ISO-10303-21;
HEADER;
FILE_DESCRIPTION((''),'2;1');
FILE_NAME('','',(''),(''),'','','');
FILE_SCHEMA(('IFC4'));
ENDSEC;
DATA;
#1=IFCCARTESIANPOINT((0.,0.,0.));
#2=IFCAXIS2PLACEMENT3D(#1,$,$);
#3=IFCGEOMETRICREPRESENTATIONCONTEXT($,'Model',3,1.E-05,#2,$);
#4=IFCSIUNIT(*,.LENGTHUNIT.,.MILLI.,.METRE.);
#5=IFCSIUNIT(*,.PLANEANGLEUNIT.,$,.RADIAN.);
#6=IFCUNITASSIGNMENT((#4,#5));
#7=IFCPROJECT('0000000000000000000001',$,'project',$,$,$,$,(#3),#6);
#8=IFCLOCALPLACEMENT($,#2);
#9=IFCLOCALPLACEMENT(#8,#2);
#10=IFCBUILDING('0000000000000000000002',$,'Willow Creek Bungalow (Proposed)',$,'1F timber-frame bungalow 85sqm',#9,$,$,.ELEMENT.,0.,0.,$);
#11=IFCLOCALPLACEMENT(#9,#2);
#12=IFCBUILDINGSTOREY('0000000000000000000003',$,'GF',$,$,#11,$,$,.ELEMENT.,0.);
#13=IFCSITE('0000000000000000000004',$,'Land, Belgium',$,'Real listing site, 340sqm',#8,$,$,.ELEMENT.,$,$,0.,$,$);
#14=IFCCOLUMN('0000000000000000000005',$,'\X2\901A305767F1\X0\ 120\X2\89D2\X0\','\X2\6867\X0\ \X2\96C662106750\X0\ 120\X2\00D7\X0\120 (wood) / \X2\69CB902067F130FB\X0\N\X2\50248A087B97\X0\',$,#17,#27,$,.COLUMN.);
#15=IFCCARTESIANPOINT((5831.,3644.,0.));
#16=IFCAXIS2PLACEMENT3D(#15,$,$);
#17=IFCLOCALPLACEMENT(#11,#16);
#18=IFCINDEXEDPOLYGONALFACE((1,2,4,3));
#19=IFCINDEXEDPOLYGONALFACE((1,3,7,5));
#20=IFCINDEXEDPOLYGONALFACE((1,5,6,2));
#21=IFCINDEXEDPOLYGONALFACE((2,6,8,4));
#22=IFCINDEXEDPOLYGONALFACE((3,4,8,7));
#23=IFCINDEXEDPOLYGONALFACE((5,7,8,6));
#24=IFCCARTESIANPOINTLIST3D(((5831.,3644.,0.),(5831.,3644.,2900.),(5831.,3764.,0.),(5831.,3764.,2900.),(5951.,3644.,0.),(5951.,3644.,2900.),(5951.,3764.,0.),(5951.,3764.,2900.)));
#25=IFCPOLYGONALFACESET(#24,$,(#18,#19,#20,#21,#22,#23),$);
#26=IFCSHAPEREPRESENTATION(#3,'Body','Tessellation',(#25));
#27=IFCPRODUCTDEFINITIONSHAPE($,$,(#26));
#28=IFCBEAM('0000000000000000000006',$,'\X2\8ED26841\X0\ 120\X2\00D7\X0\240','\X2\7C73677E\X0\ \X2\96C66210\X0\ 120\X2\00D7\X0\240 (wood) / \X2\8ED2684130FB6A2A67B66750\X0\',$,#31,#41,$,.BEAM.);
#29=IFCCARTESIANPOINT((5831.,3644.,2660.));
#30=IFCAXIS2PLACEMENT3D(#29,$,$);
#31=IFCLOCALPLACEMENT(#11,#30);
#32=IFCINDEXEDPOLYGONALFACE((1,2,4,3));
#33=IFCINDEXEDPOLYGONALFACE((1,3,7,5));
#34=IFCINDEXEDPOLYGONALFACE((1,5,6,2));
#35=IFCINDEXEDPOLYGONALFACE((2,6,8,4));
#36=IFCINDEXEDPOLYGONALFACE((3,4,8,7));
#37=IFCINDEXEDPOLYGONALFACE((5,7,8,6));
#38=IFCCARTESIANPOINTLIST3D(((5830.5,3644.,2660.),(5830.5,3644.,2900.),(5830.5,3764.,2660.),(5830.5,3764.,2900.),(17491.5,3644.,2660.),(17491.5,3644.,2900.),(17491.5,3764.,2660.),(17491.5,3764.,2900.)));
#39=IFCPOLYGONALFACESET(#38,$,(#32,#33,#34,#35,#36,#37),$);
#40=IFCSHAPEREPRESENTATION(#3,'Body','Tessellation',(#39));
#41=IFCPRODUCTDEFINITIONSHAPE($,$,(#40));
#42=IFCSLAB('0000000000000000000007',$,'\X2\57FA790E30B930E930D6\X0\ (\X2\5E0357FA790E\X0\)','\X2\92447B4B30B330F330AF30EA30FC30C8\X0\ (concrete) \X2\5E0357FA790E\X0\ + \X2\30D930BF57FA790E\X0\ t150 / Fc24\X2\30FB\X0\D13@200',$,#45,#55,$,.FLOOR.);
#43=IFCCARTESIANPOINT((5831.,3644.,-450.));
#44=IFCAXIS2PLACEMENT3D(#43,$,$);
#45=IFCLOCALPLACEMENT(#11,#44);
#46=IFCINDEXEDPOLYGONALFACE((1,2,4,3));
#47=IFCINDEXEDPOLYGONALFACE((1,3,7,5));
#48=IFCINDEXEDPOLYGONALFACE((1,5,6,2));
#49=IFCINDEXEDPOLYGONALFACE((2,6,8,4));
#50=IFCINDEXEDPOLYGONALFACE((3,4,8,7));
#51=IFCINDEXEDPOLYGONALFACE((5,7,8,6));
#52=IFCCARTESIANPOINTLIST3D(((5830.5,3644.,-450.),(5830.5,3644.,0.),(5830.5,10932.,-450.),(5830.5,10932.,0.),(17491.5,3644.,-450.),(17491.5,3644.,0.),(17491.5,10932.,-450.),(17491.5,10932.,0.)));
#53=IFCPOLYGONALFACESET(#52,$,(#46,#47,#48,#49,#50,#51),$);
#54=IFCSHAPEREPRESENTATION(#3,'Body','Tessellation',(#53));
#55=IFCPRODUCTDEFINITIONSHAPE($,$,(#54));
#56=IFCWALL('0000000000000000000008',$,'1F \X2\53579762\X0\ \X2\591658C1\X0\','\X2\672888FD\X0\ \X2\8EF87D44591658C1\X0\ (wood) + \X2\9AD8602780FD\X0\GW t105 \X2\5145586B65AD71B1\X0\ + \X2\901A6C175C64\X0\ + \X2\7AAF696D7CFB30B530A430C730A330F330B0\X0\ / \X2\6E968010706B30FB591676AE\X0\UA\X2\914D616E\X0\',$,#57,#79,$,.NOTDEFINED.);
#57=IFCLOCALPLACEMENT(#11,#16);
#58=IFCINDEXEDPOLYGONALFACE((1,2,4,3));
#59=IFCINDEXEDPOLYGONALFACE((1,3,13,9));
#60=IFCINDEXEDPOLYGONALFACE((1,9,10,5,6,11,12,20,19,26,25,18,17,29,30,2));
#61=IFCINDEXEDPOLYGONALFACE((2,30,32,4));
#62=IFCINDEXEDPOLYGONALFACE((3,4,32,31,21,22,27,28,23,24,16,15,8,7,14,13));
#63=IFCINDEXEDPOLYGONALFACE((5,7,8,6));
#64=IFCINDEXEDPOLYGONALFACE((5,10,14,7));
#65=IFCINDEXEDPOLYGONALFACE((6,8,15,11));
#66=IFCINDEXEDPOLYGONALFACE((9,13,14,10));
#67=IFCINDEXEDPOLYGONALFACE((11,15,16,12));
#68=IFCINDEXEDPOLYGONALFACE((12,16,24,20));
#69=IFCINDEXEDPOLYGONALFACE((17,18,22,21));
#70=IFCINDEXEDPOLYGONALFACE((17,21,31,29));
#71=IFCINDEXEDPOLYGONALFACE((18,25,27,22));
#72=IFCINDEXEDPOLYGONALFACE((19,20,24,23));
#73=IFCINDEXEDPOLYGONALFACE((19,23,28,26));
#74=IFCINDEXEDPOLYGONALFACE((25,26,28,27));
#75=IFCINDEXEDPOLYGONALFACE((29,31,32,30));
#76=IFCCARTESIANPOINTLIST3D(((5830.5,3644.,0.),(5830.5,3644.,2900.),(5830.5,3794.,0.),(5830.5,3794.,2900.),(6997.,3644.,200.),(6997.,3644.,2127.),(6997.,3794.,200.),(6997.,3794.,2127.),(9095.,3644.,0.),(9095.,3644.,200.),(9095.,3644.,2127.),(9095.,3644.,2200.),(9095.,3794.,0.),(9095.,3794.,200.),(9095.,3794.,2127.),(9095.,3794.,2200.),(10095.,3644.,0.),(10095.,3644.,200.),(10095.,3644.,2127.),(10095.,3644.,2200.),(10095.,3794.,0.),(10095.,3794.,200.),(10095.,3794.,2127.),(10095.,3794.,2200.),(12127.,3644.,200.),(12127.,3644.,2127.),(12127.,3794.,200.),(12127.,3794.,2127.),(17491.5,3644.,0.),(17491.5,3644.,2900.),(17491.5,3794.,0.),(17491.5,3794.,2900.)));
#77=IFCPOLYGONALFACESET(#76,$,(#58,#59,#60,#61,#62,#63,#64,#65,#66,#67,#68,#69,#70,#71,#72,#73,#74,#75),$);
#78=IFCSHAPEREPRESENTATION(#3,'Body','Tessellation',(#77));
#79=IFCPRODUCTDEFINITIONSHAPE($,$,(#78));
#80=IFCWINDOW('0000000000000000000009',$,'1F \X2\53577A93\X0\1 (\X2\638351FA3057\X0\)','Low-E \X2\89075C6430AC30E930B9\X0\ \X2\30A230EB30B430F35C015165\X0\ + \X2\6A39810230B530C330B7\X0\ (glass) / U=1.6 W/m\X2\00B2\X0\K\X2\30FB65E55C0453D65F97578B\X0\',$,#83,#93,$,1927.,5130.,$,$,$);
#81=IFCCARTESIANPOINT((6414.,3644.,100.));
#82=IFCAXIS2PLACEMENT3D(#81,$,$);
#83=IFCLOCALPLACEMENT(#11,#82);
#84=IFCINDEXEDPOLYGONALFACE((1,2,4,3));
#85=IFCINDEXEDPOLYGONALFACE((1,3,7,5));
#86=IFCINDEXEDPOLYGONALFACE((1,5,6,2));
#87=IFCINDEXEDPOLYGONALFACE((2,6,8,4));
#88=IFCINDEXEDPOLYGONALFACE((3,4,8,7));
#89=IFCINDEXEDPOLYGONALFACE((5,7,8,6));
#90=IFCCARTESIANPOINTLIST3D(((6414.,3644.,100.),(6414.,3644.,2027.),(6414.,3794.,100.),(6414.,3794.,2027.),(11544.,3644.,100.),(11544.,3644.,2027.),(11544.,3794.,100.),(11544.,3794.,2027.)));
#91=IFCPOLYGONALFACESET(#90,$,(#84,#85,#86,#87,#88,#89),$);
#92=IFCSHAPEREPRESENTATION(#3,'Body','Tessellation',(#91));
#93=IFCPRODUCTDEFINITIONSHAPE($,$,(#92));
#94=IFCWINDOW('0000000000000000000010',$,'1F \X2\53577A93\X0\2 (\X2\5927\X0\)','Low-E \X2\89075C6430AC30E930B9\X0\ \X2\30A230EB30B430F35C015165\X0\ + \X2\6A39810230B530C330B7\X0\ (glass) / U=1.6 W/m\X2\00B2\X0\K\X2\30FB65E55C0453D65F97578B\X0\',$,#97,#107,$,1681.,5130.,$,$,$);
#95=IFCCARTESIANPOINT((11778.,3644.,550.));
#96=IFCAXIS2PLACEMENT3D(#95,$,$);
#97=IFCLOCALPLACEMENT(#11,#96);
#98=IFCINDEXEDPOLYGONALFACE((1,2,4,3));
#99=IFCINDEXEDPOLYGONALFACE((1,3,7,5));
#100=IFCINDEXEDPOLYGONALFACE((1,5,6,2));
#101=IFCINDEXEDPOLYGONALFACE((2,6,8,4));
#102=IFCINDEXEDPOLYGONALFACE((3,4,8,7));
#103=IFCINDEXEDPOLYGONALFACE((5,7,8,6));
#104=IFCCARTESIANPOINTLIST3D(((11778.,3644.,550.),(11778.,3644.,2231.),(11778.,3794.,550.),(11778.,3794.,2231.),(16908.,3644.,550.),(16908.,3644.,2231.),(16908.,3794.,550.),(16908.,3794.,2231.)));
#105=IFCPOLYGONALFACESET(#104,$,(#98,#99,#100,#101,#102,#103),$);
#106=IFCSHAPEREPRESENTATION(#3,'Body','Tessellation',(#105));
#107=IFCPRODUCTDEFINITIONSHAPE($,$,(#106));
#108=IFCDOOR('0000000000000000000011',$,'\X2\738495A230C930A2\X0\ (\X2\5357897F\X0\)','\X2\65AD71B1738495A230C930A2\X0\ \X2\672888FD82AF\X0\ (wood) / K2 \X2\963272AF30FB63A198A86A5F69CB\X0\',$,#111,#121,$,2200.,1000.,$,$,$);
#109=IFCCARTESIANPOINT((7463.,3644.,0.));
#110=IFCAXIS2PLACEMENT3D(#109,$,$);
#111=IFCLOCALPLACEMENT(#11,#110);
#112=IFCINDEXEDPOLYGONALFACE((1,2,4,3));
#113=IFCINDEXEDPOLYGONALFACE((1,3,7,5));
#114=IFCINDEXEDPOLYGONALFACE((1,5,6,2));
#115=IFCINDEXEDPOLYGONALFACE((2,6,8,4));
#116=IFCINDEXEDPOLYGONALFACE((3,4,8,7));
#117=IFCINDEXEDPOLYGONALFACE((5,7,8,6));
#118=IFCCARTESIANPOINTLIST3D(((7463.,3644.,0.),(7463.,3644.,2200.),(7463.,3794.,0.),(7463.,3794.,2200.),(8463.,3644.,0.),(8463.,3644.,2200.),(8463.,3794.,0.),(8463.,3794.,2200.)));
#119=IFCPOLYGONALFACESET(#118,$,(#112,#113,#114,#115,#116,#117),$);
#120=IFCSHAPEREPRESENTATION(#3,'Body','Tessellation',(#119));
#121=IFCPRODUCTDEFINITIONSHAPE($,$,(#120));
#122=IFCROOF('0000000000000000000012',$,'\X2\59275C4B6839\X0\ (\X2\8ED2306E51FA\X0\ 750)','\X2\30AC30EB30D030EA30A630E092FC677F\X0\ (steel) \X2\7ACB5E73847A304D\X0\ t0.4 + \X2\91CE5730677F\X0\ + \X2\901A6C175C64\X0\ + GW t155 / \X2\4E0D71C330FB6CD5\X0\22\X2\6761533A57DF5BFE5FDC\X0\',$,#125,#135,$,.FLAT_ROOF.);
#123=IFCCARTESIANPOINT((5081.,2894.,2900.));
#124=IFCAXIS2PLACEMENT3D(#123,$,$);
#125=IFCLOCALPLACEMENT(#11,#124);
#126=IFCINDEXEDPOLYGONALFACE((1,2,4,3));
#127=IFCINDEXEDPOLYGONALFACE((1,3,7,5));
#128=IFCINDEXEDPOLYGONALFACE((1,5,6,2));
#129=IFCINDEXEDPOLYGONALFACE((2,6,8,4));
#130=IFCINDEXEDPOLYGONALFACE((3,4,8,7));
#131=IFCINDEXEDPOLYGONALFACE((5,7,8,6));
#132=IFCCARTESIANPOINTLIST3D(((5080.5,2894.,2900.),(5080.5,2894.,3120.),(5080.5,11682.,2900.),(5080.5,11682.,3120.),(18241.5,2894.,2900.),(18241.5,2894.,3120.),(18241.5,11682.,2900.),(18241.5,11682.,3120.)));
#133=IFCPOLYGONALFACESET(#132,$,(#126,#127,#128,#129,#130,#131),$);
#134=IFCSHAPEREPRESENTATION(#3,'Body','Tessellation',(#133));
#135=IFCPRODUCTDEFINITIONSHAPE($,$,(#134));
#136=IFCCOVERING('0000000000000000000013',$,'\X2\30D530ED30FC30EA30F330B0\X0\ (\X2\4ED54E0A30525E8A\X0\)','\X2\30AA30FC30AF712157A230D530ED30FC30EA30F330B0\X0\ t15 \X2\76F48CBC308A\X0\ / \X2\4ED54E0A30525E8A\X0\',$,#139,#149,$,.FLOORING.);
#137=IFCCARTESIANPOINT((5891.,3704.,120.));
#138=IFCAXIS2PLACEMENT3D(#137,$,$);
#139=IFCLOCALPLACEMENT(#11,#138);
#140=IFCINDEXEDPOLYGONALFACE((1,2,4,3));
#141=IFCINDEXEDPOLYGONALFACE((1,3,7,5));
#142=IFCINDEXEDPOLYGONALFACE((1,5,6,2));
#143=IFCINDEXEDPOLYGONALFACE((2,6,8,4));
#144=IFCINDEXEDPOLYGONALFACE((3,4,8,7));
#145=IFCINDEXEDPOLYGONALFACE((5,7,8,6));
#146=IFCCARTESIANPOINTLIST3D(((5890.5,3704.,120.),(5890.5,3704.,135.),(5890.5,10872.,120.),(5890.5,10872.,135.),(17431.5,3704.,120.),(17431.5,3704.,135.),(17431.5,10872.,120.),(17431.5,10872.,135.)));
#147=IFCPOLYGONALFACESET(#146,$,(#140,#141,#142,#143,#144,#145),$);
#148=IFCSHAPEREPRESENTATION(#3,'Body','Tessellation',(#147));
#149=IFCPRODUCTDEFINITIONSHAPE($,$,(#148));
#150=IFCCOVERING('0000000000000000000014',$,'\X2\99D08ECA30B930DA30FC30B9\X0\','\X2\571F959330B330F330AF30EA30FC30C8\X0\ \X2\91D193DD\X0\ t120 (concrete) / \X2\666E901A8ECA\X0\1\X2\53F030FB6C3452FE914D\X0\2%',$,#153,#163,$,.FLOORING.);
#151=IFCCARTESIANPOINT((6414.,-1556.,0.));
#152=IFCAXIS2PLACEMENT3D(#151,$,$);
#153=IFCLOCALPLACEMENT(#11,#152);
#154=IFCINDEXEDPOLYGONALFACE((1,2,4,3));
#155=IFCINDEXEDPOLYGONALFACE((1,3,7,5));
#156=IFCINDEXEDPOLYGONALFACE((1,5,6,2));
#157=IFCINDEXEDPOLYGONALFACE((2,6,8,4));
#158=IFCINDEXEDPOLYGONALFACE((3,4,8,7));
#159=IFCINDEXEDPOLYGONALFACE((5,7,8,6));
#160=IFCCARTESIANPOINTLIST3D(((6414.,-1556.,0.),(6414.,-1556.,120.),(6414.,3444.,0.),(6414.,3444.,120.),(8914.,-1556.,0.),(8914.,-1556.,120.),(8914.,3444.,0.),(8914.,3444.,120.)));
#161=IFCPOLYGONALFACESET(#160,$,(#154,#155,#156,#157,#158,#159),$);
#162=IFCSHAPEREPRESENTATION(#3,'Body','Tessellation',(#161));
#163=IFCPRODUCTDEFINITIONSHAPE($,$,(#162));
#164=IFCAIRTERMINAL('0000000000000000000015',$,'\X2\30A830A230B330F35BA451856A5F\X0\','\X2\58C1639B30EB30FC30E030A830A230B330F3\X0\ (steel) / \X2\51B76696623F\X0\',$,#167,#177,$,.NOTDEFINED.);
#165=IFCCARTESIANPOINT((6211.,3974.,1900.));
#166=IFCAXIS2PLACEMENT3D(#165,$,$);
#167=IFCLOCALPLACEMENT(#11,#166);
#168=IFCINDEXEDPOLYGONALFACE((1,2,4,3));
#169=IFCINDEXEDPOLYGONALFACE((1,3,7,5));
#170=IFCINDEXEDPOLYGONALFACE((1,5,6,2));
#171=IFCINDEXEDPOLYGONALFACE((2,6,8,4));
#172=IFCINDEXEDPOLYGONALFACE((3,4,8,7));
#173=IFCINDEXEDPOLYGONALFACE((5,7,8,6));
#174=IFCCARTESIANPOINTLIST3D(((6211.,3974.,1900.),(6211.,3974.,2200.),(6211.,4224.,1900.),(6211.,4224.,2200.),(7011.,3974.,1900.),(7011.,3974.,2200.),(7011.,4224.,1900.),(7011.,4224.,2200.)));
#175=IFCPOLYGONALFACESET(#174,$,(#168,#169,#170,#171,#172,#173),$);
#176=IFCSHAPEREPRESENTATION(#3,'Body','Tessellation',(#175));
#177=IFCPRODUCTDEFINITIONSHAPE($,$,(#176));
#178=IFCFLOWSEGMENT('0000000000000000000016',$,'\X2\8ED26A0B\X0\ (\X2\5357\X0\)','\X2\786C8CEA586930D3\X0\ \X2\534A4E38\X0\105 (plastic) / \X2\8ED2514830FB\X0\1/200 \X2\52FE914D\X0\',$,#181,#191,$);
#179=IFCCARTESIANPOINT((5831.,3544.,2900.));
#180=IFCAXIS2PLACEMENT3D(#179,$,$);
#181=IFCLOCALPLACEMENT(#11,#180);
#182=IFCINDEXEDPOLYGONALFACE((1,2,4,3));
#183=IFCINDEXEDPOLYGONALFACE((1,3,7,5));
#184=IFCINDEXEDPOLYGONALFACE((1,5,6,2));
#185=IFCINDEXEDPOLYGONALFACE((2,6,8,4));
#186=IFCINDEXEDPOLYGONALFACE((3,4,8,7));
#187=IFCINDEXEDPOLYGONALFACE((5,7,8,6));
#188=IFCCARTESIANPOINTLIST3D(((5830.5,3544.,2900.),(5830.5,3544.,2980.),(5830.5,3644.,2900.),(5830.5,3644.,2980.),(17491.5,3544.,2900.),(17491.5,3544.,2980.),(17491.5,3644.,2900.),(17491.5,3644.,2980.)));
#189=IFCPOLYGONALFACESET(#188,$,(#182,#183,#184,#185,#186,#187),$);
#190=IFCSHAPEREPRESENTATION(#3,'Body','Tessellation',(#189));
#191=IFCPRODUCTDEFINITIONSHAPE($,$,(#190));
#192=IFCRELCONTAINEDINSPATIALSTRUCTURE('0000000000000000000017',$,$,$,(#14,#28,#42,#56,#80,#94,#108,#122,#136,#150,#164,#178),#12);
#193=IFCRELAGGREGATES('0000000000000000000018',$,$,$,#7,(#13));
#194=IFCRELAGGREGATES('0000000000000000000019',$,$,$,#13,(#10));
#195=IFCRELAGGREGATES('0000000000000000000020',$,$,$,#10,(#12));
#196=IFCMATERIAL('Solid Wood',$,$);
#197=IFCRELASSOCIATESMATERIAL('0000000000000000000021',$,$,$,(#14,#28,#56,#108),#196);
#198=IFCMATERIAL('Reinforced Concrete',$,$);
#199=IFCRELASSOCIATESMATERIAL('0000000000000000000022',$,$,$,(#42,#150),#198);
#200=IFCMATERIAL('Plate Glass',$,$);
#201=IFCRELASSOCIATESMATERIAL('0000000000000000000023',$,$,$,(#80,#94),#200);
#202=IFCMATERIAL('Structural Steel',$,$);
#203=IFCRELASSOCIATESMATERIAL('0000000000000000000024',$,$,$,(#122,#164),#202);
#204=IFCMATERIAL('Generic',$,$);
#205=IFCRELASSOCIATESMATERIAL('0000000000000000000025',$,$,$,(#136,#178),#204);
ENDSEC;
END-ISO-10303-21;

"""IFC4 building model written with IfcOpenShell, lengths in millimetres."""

from ifc_helpers import new_model, si_unit, frame, frame_2d, origin, place, context, project, spatial, rectangle, extrude, material, element, fill, save


model = new_model("IFC4")

# Units and contexts
model_context = context("Model", 3, precision=1e-05, world=origin())
ifc_project = project(units=[si_unit("LENGTHUNIT", "METRE", prefix="MILLI"), si_unit("PLANEANGLEUNIT", "RADIAN")], contexts=[model_context])

# Site, building, storey
site_placement = place(None, origin())
site = spatial("IfcSite", under=ifc_project, at=site_placement, Name="Land, Belgium", ObjectType="Real listing site, 340sqm", CompositionType="ELEMENT", RefElevation=0.0)
building_placement = place(site_placement, origin())
building = spatial("IfcBuilding", under=site, at=building_placement, Name="Willow Creek Bungalow (Proposed)", ObjectType="1F timber-frame bungalow 85sqm", CompositionType="ELEMENT", ElevationOfRefHeight=0.0, ElevationOfTerrain=0.0)
storey_placement = place(building_placement, origin())
storey = spatial("IfcBuildingStorey", under=building, at=storey_placement, Name="GF", CompositionType="ELEMENT", Elevation=0.0)

# Column
ifc_material_1 = material(Name="Solid Wood")
column_1_placement = place(storey_placement, frame((5831.0, 3644.0, 0.0)))
element("IfcColumn", 1, at=column_1_placement, inside=storey, material=ifc_material_1, Name="通し柱 120角", Description="桧 集成材 120×120 (wood) / 構造柱・N値計算", PredefinedType="COLUMN", context=model_context, shape_type="SweptSolid", body=[
    extrude(rectangle(XDim=120.0, YDim=120.0, at=frame_2d((60.0, 60.0))), frame((5831.0, 3644.0, 0.0)), (0.0, 0.0, 1.0), 2900.0),
])

# Beam
beam_1_placement = place(storey_placement, frame((5831.0, 3644.0, 2660.0)))
element("IfcBeam", 2, at=beam_1_placement, inside=storey, material=ifc_material_1, Name="軒桁 120×240", Description="米松 集成 120×240 (wood) / 軒桁・横架材", PredefinedType="BEAM", context=model_context, shape_type="SweptSolid", body=[
    extrude(rectangle(XDim=11661.0, YDim=120.0, at=frame_2d((5830.0, 60.0))), frame((5831.0, 3644.0, 2660.0)), (0.0, 0.0, 1.0), 240.0),
])

# Slab
ifc_material_2 = material(Name="Reinforced Concrete")
slab_1_placement = place(storey_placement, frame((5831.0, 3644.0, -450.0)))
element("IfcSlab", 3, at=slab_1_placement, inside=storey, material=ifc_material_2, Name="基礎スラブ (布基礎)", Description="鉄筋コンクリート (concrete) 布基礎 + ベタ基礎 t150 / Fc24・D13@200", PredefinedType="FLOOR", context=model_context, shape_type="SweptSolid", body=[
    extrude(rectangle(XDim=11661.0, YDim=7288.0, at=frame_2d((5830.0, 3644.0))), frame((5831.0, 3644.0, -450.0)), (0.0, 0.0, 1.0), 450.0),
])

# Wall, openings, windows, door
wall_1_placement = place(storey_placement, frame((5831.0, 3644.0, 0.0)))
wall_1 = element("IfcWall", 4, at=wall_1_placement, inside=storey, material=ifc_material_1, Name="1F 南面 外壁", Description="木製 軸組外壁 (wood) + 高性能GW t105 充填断熱 + 通気層 + 窯業系サイディング / 準耐火・外皮UA配慮", PredefinedType="NOTDEFINED", context=model_context, shape_type="SweptSolid", body=[
    extrude(rectangle(XDim=11661.0, YDim=150.0, at=frame_2d((5830.0, 75.0))), frame((5831.0, 3644.0, 0.0)), (0.0, 0.0, 1.0), 2900.0),
])
opening_1_placement = place(storey_placement, frame((6414.0, 3644.0, 100.0)))
opening_1 = element("IfcOpeningElement", 5, at=opening_1_placement, cuts=wall_1, PredefinedType="NOTDEFINED", context=model_context, shape_type="SweptSolid", body=[
    extrude(rectangle(XDim=5130.0, YDim=150.0, at=frame_2d((2565.0, 75.0))), frame((6414.0, 3644.0, 100.0)), (0.0, 0.0, 1.0), 1927.0),
])
opening_2_placement = place(storey_placement, frame((11778.0, 3644.0, 550.0)))
opening_2 = element("IfcOpeningElement", 6, at=opening_2_placement, cuts=wall_1, PredefinedType="NOTDEFINED", context=model_context, shape_type="SweptSolid", body=[
    extrude(rectangle(XDim=5130.0, YDim=150.0, at=frame_2d((2565.0, 75.0))), frame((11778.0, 3644.0, 550.0)), (0.0, 0.0, 1.0), 1681.0),
])
opening_3_placement = place(storey_placement, frame((7463.0, 3644.0, 0.0)))
opening_3 = element("IfcOpeningElement", 7, at=opening_3_placement, cuts=wall_1, PredefinedType="NOTDEFINED", context=model_context, shape_type="SweptSolid", body=[
    extrude(rectangle(XDim=1000.0, YDim=150.0, at=frame_2d((500.0, 75.0))), frame((7463.0, 3644.0, 0.0)), (0.0, 0.0, 1.0), 2200.0),
])
ifc_material_3 = material(Name="Plate Glass")
window_1_placement = place(storey_placement, frame((6414.0, 3644.0, 100.0)))
window_1 = element("IfcWindow", 8, at=window_1_placement, inside=storey, material=ifc_material_3, Name="1F 南窓1 (掃出し)", Description="Low-E 複層ガラス アルゴン封入 + 樹脂サッシ (glass) / U=1.6 W/m²K・日射取得型", OverallHeight=1927.0, OverallWidth=5130.0, context=model_context, shape_type="SweptSolid", body=[
    extrude(rectangle(XDim=5130.0, YDim=150.0, at=frame_2d((2565.0, 75.0))), frame((6414.0, 3644.0, 100.0)), (0.0, 0.0, 1.0), 1927.0),
])
fill(opening_1, window_1)
window_2_placement = place(storey_placement, frame((11778.0, 3644.0, 550.0)))
window_2 = element("IfcWindow", 9, at=window_2_placement, inside=storey, material=ifc_material_3, Name="1F 南窓2 (大)", Description="Low-E 複層ガラス アルゴン封入 + 樹脂サッシ (glass) / U=1.6 W/m²K・日射取得型", OverallHeight=1681.0, OverallWidth=5130.0, context=model_context, shape_type="SweptSolid", body=[
    extrude(rectangle(XDim=5130.0, YDim=150.0, at=frame_2d((2565.0, 75.0))), frame((11778.0, 3644.0, 550.0)), (0.0, 0.0, 1.0), 1681.0),
])
fill(opening_2, window_2)
door_placement = place(storey_placement, frame((7463.0, 3644.0, 0.0)))
door = element("IfcDoor", 10, at=door_placement, inside=storey, material=ifc_material_1, Name="玄関ドア (南西)", Description="断熱玄関ドア 木製芯 (wood) / K2 防犯・採風機構", OverallHeight=2200.0, OverallWidth=1000.0, context=model_context, shape_type="SweptSolid", body=[
    extrude(rectangle(XDim=1000.0, YDim=150.0, at=frame_2d((500.0, 75.0))), frame((7463.0, 3644.0, 0.0)), (0.0, 0.0, 1.0), 2200.0),
])
fill(opening_3, door)

# Roof
ifc_material_4 = material(Name="Structural Steel")
roof_placement = place(storey_placement, frame((5081.0, 2894.0, 2900.0)))
element("IfcRoof", 11, at=roof_placement, inside=storey, material=ifc_material_4, Name="大屋根 (軒の出 750)", Description="ガルバリウム鋼板 (steel) 立平葺き t0.4 + 野地板 + 通気層 + GW t155 / 不燃・法22条区域対応", PredefinedType="FLAT_ROOF", context=model_context, shape_type="SweptSolid", body=[
    extrude(rectangle(XDim=13161.0, YDim=8788.0, at=frame_2d((6580.0, 4394.0))), frame((5081.0, 2894.0, 2900.0)), (0.0, 0.0, 1.0), 220.0),
])

# Coverings
ifc_material_5 = material(Name="Generic")
covering_1_placement = place(storey_placement, frame((5891.0, 3704.0, 120.0)))
element("IfcCovering", 12, at=covering_1_placement, inside=storey, material=ifc_material_5, Name="フローリング (仕上げ床)", Description="オーク無垢フローリング t15 直貼り / 仕上げ床", PredefinedType="FLOORING", context=model_context, shape_type="SweptSolid", body=[
    extrude(rectangle(XDim=11541.0, YDim=7168.0, at=frame_2d((5770.0, 3584.0))), frame((5891.0, 3704.0, 120.0)), (0.0, 0.0, 1.0), 15.0),
])
covering_2_placement = place(storey_placement, frame((6414.0, -1556.0, 0.0)))
element("IfcCovering", 13, at=covering_2_placement, inside=storey, material=ifc_material_2, Name="駐車スペース", Description="土間コンクリート 金鏝 t120 (concrete) / 普通車1台・水勾配2%", PredefinedType="FLOORING", context=model_context, shape_type="SweptSolid", body=[
    extrude(rectangle(XDim=2500.0, YDim=5000.0, at=frame_2d((1250.0, 2500.0))), frame((6414.0, -1556.0, 0.0)), (0.0, 0.0, 1.0), 120.0),
])

# Air terminal
air_terminal_placement = place(storey_placement, frame((6211.0, 3974.0, 1900.0)))
element("IfcAirTerminal", 14, at=air_terminal_placement, inside=storey, material=ifc_material_4, Name="エアコン室内機", Description="壁掛ルームエアコン (steel) / 冷暖房", PredefinedType="NOTDEFINED", context=model_context, shape_type="SweptSolid", body=[
    extrude(rectangle(XDim=800.0, YDim=250.0, at=frame_2d((400.0, 125.0))), frame((6211.0, 3974.0, 1900.0)), (0.0, 0.0, 1.0), 300.0),
])

# Flow segment
flow_segment_1_placement = place(storey_placement, frame((5831.0, 3544.0, 2900.0)))
element("IfcFlowSegment", 15, at=flow_segment_1_placement, inside=storey, material=ifc_material_5, Name="軒樋 (南)", Description="硬質塩ビ 半丸105 (plastic) / 軒先・1/200 勾配", context=model_context, shape_type="SweptSolid", body=[
    extrude(rectangle(XDim=11661.0, YDim=100.0, at=frame_2d((5830.0, 50.0))), frame((5831.0, 3544.0, 2900.0)), (0.0, 0.0, 1.0), 80.0),
])

save(model, "model.ifc")
